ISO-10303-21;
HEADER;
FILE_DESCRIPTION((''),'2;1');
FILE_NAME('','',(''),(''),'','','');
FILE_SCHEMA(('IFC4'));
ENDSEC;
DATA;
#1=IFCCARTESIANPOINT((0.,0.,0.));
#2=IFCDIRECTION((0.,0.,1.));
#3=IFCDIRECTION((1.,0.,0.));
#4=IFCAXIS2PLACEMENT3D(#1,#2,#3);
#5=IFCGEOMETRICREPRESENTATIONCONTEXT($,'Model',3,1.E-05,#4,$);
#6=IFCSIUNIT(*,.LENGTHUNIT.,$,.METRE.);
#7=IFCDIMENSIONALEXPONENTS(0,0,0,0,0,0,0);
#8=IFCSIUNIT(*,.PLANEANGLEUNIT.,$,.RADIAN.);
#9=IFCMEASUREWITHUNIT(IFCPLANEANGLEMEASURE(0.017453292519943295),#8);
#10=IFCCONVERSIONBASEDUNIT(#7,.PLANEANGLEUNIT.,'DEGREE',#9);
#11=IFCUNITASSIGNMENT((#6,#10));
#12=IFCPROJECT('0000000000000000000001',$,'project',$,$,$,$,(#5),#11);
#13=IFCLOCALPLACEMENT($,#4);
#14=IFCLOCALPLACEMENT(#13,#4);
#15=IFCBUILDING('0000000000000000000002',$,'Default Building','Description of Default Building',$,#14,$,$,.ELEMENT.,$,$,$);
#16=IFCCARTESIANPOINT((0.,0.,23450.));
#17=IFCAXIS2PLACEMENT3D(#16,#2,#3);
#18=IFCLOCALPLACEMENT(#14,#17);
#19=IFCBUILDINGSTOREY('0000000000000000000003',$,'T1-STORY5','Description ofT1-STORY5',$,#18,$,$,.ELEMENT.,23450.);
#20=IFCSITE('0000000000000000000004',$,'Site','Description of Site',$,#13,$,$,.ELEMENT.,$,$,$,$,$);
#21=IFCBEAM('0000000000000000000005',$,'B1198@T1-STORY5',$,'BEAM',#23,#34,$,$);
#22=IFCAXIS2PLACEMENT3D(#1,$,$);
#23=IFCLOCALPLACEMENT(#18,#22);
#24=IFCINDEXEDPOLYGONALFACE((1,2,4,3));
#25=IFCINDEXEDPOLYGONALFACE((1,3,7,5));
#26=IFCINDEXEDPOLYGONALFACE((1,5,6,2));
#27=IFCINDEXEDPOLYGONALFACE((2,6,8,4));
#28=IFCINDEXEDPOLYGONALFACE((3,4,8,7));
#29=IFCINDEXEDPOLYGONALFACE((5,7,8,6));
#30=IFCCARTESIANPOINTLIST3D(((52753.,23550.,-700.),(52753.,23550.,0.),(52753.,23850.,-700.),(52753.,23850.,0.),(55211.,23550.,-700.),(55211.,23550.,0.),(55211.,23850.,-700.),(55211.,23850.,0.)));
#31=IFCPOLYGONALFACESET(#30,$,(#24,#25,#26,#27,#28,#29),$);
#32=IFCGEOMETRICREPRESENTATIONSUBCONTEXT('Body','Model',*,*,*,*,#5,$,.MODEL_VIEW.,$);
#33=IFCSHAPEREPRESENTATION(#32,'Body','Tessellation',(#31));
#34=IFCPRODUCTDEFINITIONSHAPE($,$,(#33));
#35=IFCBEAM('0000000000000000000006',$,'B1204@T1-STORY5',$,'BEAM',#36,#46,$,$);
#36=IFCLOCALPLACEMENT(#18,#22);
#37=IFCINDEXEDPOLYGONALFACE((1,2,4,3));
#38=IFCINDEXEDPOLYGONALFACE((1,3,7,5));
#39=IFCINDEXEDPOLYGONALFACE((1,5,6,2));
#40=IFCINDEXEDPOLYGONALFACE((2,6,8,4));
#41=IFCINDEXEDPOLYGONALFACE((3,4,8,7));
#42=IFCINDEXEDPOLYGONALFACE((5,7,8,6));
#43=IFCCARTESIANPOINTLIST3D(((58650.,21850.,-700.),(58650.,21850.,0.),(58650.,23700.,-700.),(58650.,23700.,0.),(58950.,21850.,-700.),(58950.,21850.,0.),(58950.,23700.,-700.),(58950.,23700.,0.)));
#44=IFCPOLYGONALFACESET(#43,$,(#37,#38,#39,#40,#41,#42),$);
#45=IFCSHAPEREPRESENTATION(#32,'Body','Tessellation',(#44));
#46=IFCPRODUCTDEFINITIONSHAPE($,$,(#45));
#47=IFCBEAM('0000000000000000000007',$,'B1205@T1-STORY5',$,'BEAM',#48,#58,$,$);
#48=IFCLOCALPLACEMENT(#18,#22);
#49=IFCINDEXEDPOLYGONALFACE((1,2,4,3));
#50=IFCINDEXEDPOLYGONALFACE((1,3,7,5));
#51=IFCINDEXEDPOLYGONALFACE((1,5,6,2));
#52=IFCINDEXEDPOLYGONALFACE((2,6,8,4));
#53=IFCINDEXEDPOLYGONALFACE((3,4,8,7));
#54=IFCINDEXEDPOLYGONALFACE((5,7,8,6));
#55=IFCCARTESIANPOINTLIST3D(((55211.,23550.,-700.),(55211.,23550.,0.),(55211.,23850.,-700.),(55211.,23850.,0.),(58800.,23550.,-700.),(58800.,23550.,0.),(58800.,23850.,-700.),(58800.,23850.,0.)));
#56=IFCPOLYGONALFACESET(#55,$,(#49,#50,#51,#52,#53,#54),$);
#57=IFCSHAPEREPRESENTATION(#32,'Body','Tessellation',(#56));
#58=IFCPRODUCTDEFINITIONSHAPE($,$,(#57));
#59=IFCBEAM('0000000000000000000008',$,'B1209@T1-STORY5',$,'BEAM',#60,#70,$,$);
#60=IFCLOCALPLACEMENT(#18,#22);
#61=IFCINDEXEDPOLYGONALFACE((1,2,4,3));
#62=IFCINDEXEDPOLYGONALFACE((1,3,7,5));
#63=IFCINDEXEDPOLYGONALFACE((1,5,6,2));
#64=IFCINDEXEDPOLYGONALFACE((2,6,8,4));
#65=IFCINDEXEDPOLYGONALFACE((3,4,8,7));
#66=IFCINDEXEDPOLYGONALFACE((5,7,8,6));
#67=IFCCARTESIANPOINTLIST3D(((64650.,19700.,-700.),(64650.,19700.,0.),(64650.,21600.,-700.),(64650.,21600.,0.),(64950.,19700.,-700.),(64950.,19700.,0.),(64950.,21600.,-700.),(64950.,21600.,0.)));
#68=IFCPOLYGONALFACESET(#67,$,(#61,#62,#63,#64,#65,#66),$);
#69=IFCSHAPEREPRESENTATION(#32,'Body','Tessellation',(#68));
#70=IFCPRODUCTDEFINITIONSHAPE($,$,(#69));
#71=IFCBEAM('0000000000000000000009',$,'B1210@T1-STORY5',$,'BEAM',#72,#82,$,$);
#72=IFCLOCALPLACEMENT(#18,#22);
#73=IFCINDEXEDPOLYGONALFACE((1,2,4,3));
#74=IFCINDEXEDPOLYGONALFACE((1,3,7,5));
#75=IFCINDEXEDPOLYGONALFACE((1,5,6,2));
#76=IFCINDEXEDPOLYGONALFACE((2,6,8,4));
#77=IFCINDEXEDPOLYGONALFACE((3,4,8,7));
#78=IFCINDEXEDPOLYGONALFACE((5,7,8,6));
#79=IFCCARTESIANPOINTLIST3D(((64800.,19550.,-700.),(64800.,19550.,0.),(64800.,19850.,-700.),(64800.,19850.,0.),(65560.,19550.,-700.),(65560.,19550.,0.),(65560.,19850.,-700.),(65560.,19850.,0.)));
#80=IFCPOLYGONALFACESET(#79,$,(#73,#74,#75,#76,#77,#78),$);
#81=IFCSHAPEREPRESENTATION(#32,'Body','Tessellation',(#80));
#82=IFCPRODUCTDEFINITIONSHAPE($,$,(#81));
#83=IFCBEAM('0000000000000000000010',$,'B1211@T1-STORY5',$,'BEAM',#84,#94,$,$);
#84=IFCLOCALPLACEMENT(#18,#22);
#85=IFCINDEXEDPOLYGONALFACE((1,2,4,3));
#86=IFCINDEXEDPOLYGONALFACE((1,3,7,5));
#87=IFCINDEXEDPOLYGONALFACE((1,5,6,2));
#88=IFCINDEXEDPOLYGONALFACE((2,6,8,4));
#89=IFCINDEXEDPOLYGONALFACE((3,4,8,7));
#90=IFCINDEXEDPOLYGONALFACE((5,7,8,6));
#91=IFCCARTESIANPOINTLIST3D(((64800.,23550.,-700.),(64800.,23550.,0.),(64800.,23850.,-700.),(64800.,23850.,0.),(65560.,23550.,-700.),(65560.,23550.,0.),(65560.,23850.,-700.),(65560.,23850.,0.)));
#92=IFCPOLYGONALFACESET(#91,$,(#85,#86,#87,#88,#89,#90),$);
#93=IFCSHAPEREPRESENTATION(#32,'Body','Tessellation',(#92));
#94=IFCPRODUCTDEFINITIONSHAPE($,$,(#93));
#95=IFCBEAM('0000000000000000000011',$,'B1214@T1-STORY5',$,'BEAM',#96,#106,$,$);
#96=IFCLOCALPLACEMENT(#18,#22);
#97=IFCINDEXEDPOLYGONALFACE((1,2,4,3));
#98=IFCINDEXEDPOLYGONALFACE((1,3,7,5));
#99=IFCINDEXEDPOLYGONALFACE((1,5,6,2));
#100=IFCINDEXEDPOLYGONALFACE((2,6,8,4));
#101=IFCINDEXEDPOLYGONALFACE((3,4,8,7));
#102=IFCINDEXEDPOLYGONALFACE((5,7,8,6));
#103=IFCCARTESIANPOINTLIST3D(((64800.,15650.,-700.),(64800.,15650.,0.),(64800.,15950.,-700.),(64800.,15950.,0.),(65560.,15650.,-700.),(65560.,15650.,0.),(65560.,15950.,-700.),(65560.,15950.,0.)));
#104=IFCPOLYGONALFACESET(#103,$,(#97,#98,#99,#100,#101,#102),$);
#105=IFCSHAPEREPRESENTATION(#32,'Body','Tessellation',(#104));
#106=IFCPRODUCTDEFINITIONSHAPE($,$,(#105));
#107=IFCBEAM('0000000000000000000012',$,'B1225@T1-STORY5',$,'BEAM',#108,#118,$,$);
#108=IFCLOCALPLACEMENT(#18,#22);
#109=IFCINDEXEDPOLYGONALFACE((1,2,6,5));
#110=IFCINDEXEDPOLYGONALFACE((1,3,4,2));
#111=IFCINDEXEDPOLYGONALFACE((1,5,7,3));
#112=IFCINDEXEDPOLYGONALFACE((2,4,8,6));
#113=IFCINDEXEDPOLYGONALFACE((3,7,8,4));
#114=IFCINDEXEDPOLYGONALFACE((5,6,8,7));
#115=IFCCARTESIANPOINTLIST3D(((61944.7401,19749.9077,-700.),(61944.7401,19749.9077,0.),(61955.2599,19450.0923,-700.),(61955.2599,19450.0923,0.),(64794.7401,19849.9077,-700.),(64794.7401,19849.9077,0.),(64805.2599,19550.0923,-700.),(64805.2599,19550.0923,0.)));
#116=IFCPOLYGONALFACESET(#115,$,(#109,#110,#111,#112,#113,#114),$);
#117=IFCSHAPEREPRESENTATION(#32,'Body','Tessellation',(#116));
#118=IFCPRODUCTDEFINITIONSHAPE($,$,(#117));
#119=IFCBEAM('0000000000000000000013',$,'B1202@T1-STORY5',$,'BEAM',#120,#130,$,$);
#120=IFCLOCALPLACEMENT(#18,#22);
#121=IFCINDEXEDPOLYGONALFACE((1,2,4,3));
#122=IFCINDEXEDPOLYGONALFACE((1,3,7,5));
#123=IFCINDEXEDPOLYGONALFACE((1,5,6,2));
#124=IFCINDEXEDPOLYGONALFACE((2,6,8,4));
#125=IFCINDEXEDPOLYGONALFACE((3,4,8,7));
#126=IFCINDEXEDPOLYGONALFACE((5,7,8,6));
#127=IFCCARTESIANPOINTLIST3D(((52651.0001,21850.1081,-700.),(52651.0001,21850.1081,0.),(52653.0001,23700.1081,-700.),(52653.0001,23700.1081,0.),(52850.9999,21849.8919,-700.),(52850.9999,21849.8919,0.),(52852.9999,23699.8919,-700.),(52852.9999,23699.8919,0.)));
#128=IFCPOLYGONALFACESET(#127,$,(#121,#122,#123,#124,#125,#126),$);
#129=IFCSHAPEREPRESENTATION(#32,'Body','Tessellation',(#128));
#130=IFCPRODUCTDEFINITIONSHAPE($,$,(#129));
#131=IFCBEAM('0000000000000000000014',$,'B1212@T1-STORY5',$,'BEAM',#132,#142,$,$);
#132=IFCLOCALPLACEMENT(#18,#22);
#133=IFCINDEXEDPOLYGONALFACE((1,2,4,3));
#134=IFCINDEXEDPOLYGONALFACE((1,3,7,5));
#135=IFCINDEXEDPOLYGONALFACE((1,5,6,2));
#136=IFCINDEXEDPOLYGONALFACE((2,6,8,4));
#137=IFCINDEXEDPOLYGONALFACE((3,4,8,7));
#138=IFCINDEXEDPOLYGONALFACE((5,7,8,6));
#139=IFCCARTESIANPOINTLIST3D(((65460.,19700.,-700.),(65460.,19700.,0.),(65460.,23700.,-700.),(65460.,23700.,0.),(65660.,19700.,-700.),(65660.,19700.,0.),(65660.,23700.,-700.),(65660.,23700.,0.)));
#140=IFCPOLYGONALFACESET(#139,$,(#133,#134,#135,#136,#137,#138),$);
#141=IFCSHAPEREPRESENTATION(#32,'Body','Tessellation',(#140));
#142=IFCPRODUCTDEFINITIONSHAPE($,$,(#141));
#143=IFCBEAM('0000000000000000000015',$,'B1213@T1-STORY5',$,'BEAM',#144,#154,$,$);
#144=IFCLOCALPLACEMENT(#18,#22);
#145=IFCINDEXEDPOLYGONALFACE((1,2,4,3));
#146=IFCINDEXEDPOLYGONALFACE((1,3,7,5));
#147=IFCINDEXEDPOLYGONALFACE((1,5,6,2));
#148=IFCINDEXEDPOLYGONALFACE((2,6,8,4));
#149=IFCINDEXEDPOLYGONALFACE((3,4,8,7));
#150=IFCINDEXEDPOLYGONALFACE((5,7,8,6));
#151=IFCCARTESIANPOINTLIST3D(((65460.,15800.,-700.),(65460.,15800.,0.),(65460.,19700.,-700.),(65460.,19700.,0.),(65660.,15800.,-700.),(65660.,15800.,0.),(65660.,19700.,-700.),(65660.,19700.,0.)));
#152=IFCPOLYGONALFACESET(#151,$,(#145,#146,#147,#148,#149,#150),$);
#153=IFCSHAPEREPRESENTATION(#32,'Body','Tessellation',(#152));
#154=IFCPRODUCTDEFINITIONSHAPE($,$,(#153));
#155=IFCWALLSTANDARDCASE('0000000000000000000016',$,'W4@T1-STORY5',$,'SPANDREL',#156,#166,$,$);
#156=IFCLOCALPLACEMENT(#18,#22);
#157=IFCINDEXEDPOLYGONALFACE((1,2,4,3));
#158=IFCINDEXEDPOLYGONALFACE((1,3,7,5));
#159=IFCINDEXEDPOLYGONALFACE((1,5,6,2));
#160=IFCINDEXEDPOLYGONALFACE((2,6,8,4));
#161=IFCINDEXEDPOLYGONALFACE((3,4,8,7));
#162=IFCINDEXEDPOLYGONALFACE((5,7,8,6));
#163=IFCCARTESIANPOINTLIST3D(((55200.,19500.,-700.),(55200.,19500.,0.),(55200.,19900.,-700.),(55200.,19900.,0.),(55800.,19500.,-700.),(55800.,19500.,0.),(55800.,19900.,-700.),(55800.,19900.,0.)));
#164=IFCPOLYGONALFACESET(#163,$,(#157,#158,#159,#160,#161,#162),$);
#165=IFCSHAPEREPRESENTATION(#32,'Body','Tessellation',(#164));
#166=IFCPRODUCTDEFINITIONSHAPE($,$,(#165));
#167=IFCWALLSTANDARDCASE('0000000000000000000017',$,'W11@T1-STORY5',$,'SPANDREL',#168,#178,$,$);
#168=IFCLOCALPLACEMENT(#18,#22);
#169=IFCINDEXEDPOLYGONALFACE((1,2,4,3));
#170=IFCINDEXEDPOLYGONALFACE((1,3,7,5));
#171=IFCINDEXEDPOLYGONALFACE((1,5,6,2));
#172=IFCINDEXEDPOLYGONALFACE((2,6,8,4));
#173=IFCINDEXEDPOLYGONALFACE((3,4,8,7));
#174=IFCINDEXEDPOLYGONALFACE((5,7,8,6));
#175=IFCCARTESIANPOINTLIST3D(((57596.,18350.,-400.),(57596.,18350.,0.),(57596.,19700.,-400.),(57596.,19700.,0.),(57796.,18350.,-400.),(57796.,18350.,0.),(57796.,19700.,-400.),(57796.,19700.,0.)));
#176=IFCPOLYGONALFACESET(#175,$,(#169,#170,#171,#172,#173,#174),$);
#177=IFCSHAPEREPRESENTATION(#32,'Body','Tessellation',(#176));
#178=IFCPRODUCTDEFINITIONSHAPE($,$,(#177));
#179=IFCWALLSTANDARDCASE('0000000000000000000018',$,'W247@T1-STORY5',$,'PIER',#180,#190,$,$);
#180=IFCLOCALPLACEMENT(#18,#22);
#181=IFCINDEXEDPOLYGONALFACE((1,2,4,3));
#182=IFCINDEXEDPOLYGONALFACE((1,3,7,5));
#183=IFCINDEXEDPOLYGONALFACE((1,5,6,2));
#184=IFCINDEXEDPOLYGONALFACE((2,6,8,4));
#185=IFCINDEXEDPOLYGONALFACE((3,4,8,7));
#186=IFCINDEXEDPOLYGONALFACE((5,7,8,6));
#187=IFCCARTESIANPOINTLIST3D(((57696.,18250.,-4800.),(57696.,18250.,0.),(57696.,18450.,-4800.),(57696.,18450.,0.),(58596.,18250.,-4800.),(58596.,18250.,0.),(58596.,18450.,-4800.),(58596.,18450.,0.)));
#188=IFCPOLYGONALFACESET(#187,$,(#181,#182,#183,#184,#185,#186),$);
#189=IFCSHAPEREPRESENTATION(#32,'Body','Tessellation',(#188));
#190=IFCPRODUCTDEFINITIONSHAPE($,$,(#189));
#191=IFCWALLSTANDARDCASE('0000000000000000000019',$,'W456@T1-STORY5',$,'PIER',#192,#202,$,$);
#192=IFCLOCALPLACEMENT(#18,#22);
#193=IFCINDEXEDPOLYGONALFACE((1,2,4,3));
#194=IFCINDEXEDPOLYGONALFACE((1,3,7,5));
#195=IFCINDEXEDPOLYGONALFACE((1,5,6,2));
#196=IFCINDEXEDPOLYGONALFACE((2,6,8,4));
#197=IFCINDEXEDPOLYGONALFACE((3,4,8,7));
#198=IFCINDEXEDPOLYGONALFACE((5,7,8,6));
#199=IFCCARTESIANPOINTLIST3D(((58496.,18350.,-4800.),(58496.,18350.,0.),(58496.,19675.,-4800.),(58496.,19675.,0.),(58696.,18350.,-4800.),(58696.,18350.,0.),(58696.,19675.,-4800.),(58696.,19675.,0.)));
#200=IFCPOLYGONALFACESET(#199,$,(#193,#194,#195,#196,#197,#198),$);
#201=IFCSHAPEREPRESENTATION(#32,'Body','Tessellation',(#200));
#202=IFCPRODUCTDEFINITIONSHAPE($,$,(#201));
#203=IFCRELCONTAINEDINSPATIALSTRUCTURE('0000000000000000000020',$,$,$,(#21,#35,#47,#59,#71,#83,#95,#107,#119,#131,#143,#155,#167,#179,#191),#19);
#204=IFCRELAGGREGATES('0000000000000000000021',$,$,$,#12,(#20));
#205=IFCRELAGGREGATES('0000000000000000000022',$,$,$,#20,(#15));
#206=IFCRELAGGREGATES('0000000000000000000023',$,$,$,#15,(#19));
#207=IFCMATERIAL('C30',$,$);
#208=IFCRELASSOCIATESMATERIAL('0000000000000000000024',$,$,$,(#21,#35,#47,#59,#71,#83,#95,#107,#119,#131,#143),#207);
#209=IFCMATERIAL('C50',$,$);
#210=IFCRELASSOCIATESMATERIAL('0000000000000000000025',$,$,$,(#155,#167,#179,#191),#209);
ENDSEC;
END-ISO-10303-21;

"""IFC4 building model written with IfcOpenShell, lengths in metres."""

from ifc_helpers import new_model, entity, si_unit, converted_unit, frame, origin_with_axes, place, context, subcontext, project, spatial, indexed_curve, rectangle, outline, extrude, material, element, save


model = new_model("IFC4")

# Units and contexts
model_context = context("Model", 3, precision=1e-05, world=origin_with_axes())
body_context = subcontext(model_context, "Body", "Model", "MODEL_VIEW")
ifc_project = project(units=[si_unit("LENGTHUNIT", "METRE"), converted_unit("PLANEANGLEUNIT", "DEGREE", entity("IfcPlaneAngleMeasure", 0.017453292519943295), si_unit("PLANEANGLEUNIT", "RADIAN"), dimensions=[0, 0, 0, 0, 0, 0, 0])], contexts=[model_context])

# Site, building, storey
site_placement = place(None, origin_with_axes())
site = spatial("IfcSite", under=ifc_project, at=site_placement, Name="Site", Description="Description of Site", CompositionType="ELEMENT")
building_placement = place(site_placement, origin_with_axes())
building = spatial("IfcBuilding", under=site, at=building_placement, Name="Default Building", Description="Description of Default Building", CompositionType="ELEMENT")
storey_placement = place(building_placement, frame((0.0, 0.0, 23450.0), z_axis=(0.0, 0.0, 1.0), x_axis=(1.0, 0.0, 0.0)))
storey = spatial("IfcBuildingStorey", under=building, at=storey_placement, Name="T1-STORY5", Description="Description ofT1-STORY5", CompositionType="ELEMENT", Elevation=23450.0)

# Beams
ifc_material_1 = material(Name="C30")
beam_1_placement = place(storey_placement, frame((52753.0, 23700.0, -350.0), z_axis=(1.0, 0.0, 0.0), x_axis=(0.0, 1.0, 0.0)))
element("IfcBeam", 1, at=beam_1_placement, inside=storey, material=ifc_material_1, Name="B1198@T1-STORY5", ObjectType="BEAM", context=body_context, shape_type="SweptSolid", body=[
    extrude(rectangle(XDim=300.0, YDim=700.0), origin_with_axes(), (0.0, 0.0, 1.0), 2458.0),
])
beam_2_placement = place(storey_placement, frame((58800.0, 21850.0, -350.0), z_axis=(0.0, 1.0, 0.0), x_axis=(-1.0, 0.0, 0.0)))
element("IfcBeam", 2, at=beam_2_placement, inside=storey, material=ifc_material_1, Name="B1204@T1-STORY5", ObjectType="BEAM", context=body_context, shape_type="SweptSolid", body=[
    extrude(rectangle(XDim=300.0, YDim=700.0), origin_with_axes(), (0.0, 0.0, 1.0), 1850.0),
])
beam_3_placement = place(storey_placement, frame((55211.0, 23700.0, -350.0), z_axis=(1.0, 0.0, 0.0), x_axis=(0.0, 1.0, 0.0)))
element("IfcBeam", 3, at=beam_3_placement, inside=storey, material=ifc_material_1, Name="B1205@T1-STORY5", ObjectType="BEAM", context=body_context, shape_type="SweptSolid", body=[
    extrude(rectangle(XDim=300.0, YDim=700.0), origin_with_axes(), (0.0, 0.0, 1.0), 3589.0),
])
beam_4_placement = place(storey_placement, frame((64800.0, 19700.0, -350.0), z_axis=(0.0, 1.0, 0.0), x_axis=(-1.0, 0.0, 0.0)))
element("IfcBeam", 4, at=beam_4_placement, inside=storey, material=ifc_material_1, Name="B1209@T1-STORY5", ObjectType="BEAM", context=body_context, shape_type="SweptSolid", body=[
    extrude(rectangle(XDim=300.0, YDim=700.0), origin_with_axes(), (0.0, 0.0, 1.0), 1900.0),
])
for number, where, z_axis, x_axis, name in (
    (5, (64800.0, 19700.0, -350.0), (1.0, 0.0, 0.0), (0.0, 1.0, 0.0), "B1210@T1-STORY5"),
    (6, (64800.0, 23700.0, -350.0), (1.0, 0.0, 0.0), (0.0, 1.0, 0.0), "B1211@T1-STORY5"),
    (7, (64800.0, 15800.0, -350.0), (1.0, 0.0, 0.0), (0.0, 1.0, 0.0), "B1214@T1-STORY5"),
):
    element("IfcBeam", number, at=place(storey_placement, frame(where, z_axis=z_axis, x_axis=x_axis)), inside=storey, material=ifc_material_1, Name=name, ObjectType="BEAM", context=body_context, shape_type="SweptSolid", body=[
        extrude(rectangle(XDim=300.0, YDim=700.0), origin_with_axes(), (0.0, 0.0, 1.0), 760.0),
    ])
beam_5_placement = place(storey_placement, frame((61950.0, 19600.0, -350.0), z_axis=(0.999385, 0.035066, 0.0), x_axis=(-0.035066, 0.999385, 0.0)))
element("IfcBeam", 8, at=beam_5_placement, inside=storey, material=ifc_material_1, Name="B1225@T1-STORY5", ObjectType="BEAM", context=body_context, shape_type="SweptSolid", body=[
    extrude(rectangle(XDim=300.0, YDim=700.0), origin_with_axes(), (0.0, 0.0, 1.0), 2851.7538),
])
beam_6_placement = place(storey_placement, frame((52751.0, 21850.0, -350.0), z_axis=(0.001081, 0.999999, 0.0), x_axis=(-0.999999, 0.001081, 0.0)))
element("IfcBeam", 9, at=beam_6_placement, inside=storey, material=ifc_material_1, Name="B1202@T1-STORY5", ObjectType="BEAM", context=body_context, shape_type="SweptSolid", body=[
    extrude(rectangle(XDim=200.0, YDim=700.0), origin_with_axes(), (0.0, 0.0, 1.0), 1850.0011),
])
beam_7_placement = place(storey_placement, frame((65560.0, 19700.0, -350.0), z_axis=(0.0, 1.0, 0.0), x_axis=(-1.0, 0.0, 0.0)))
element("IfcBeam", 10, at=beam_7_placement, inside=storey, material=ifc_material_1, Name="B1212@T1-STORY5", ObjectType="BEAM", context=body_context, shape_type="SweptSolid", body=[
    extrude(rectangle(XDim=200.0, YDim=700.0), origin_with_axes(), (0.0, 0.0, 1.0), 4000.0),
])
beam_8_placement = place(storey_placement, frame((65560.0, 15800.0, -350.0), z_axis=(0.0, 1.0, 0.0), x_axis=(-1.0, 0.0, 0.0)))
element("IfcBeam", 11, at=beam_8_placement, inside=storey, material=ifc_material_1, Name="B1213@T1-STORY5", ObjectType="BEAM", context=body_context, shape_type="SweptSolid", body=[
    extrude(rectangle(XDim=200.0, YDim=700.0), origin_with_axes(), (0.0, 0.0, 1.0), 3900.0),
])
ifc_material_2 = material(Name="C50")

# Walls
wall_1_placement = place(storey_placement, frame((55200.0, 19700.0, -700.0), z_axis=(0.0, 0.0, 1.0), x_axis=(1.0, 0.0, 0.0)))
element("IfcWallStandardCase", 12, at=wall_1_placement, inside=storey, material=ifc_material_2, Name="W4@T1-STORY5", ObjectType="SPANDREL", context=body_context, shape_type="SweptSolid", body=[
    extrude(outline(indexed_curve([(0.0, -200.0), (0.0, 200.0), (600.0, 200.0), (600.0, -200.0), (0.0, -200.0)], self_intersect=False)), origin_with_axes(), (0.0, 0.0, 1.0), 700.0),
])
wall_2_placement = place(storey_placement, frame((57696.0, 18350.0, -400.0), z_axis=(0.0, 0.0, 1.0), x_axis=(0.0, 1.0, 0.0)))
element("IfcWallStandardCase", 13, at=wall_2_placement, inside=storey, material=ifc_material_2, Name="W11@T1-STORY5", ObjectType="SPANDREL", context=body_context, shape_type="SweptSolid", body=[
    extrude(outline(indexed_curve([(0.0, -100.0), (0.0, 100.0), (1350.0, 100.0), (1350.0, -100.0), (0.0, -100.0)], self_intersect=False)), origin_with_axes(), (0.0, 0.0, 1.0), 400.0),
])
wall_3_placement = place(storey_placement, frame((57696.0, 18350.0, -4800.0), z_axis=(0.0, 0.0, 1.0), x_axis=(1.0, 0.0, 0.0)))
element("IfcWallStandardCase", 14, at=wall_3_placement, inside=storey, material=ifc_material_2, Name="W247@T1-STORY5", ObjectType="PIER", context=body_context, shape_type="SweptSolid", body=[
    extrude(outline(indexed_curve([(0.0, -100.0), (0.0, 100.0), (900.0, 100.0), (900.0, -100.0), (0.0, -100.0)], self_intersect=False)), origin_with_axes(), (0.0, 0.0, 1.0), 4800.0),
])
wall_4_placement = place(storey_placement, frame((58596.0, 18350.0, -4800.0), z_axis=(0.0, 0.0, 1.0), x_axis=(0.0, 1.0, 0.0)))
element("IfcWallStandardCase", 15, at=wall_4_placement, inside=storey, material=ifc_material_2, Name="W456@T1-STORY5", ObjectType="PIER", context=body_context, shape_type="SweptSolid", body=[
    extrude(outline(indexed_curve([(0.0, -100.0), (0.0, 100.0), (1325.0, 100.0), (1325.0, -100.0), (0.0, -100.0)], self_intersect=False)), origin_with_axes(), (0.0, 0.0, 1.0), 4800.0),
])

save(model, "model.ifc")
